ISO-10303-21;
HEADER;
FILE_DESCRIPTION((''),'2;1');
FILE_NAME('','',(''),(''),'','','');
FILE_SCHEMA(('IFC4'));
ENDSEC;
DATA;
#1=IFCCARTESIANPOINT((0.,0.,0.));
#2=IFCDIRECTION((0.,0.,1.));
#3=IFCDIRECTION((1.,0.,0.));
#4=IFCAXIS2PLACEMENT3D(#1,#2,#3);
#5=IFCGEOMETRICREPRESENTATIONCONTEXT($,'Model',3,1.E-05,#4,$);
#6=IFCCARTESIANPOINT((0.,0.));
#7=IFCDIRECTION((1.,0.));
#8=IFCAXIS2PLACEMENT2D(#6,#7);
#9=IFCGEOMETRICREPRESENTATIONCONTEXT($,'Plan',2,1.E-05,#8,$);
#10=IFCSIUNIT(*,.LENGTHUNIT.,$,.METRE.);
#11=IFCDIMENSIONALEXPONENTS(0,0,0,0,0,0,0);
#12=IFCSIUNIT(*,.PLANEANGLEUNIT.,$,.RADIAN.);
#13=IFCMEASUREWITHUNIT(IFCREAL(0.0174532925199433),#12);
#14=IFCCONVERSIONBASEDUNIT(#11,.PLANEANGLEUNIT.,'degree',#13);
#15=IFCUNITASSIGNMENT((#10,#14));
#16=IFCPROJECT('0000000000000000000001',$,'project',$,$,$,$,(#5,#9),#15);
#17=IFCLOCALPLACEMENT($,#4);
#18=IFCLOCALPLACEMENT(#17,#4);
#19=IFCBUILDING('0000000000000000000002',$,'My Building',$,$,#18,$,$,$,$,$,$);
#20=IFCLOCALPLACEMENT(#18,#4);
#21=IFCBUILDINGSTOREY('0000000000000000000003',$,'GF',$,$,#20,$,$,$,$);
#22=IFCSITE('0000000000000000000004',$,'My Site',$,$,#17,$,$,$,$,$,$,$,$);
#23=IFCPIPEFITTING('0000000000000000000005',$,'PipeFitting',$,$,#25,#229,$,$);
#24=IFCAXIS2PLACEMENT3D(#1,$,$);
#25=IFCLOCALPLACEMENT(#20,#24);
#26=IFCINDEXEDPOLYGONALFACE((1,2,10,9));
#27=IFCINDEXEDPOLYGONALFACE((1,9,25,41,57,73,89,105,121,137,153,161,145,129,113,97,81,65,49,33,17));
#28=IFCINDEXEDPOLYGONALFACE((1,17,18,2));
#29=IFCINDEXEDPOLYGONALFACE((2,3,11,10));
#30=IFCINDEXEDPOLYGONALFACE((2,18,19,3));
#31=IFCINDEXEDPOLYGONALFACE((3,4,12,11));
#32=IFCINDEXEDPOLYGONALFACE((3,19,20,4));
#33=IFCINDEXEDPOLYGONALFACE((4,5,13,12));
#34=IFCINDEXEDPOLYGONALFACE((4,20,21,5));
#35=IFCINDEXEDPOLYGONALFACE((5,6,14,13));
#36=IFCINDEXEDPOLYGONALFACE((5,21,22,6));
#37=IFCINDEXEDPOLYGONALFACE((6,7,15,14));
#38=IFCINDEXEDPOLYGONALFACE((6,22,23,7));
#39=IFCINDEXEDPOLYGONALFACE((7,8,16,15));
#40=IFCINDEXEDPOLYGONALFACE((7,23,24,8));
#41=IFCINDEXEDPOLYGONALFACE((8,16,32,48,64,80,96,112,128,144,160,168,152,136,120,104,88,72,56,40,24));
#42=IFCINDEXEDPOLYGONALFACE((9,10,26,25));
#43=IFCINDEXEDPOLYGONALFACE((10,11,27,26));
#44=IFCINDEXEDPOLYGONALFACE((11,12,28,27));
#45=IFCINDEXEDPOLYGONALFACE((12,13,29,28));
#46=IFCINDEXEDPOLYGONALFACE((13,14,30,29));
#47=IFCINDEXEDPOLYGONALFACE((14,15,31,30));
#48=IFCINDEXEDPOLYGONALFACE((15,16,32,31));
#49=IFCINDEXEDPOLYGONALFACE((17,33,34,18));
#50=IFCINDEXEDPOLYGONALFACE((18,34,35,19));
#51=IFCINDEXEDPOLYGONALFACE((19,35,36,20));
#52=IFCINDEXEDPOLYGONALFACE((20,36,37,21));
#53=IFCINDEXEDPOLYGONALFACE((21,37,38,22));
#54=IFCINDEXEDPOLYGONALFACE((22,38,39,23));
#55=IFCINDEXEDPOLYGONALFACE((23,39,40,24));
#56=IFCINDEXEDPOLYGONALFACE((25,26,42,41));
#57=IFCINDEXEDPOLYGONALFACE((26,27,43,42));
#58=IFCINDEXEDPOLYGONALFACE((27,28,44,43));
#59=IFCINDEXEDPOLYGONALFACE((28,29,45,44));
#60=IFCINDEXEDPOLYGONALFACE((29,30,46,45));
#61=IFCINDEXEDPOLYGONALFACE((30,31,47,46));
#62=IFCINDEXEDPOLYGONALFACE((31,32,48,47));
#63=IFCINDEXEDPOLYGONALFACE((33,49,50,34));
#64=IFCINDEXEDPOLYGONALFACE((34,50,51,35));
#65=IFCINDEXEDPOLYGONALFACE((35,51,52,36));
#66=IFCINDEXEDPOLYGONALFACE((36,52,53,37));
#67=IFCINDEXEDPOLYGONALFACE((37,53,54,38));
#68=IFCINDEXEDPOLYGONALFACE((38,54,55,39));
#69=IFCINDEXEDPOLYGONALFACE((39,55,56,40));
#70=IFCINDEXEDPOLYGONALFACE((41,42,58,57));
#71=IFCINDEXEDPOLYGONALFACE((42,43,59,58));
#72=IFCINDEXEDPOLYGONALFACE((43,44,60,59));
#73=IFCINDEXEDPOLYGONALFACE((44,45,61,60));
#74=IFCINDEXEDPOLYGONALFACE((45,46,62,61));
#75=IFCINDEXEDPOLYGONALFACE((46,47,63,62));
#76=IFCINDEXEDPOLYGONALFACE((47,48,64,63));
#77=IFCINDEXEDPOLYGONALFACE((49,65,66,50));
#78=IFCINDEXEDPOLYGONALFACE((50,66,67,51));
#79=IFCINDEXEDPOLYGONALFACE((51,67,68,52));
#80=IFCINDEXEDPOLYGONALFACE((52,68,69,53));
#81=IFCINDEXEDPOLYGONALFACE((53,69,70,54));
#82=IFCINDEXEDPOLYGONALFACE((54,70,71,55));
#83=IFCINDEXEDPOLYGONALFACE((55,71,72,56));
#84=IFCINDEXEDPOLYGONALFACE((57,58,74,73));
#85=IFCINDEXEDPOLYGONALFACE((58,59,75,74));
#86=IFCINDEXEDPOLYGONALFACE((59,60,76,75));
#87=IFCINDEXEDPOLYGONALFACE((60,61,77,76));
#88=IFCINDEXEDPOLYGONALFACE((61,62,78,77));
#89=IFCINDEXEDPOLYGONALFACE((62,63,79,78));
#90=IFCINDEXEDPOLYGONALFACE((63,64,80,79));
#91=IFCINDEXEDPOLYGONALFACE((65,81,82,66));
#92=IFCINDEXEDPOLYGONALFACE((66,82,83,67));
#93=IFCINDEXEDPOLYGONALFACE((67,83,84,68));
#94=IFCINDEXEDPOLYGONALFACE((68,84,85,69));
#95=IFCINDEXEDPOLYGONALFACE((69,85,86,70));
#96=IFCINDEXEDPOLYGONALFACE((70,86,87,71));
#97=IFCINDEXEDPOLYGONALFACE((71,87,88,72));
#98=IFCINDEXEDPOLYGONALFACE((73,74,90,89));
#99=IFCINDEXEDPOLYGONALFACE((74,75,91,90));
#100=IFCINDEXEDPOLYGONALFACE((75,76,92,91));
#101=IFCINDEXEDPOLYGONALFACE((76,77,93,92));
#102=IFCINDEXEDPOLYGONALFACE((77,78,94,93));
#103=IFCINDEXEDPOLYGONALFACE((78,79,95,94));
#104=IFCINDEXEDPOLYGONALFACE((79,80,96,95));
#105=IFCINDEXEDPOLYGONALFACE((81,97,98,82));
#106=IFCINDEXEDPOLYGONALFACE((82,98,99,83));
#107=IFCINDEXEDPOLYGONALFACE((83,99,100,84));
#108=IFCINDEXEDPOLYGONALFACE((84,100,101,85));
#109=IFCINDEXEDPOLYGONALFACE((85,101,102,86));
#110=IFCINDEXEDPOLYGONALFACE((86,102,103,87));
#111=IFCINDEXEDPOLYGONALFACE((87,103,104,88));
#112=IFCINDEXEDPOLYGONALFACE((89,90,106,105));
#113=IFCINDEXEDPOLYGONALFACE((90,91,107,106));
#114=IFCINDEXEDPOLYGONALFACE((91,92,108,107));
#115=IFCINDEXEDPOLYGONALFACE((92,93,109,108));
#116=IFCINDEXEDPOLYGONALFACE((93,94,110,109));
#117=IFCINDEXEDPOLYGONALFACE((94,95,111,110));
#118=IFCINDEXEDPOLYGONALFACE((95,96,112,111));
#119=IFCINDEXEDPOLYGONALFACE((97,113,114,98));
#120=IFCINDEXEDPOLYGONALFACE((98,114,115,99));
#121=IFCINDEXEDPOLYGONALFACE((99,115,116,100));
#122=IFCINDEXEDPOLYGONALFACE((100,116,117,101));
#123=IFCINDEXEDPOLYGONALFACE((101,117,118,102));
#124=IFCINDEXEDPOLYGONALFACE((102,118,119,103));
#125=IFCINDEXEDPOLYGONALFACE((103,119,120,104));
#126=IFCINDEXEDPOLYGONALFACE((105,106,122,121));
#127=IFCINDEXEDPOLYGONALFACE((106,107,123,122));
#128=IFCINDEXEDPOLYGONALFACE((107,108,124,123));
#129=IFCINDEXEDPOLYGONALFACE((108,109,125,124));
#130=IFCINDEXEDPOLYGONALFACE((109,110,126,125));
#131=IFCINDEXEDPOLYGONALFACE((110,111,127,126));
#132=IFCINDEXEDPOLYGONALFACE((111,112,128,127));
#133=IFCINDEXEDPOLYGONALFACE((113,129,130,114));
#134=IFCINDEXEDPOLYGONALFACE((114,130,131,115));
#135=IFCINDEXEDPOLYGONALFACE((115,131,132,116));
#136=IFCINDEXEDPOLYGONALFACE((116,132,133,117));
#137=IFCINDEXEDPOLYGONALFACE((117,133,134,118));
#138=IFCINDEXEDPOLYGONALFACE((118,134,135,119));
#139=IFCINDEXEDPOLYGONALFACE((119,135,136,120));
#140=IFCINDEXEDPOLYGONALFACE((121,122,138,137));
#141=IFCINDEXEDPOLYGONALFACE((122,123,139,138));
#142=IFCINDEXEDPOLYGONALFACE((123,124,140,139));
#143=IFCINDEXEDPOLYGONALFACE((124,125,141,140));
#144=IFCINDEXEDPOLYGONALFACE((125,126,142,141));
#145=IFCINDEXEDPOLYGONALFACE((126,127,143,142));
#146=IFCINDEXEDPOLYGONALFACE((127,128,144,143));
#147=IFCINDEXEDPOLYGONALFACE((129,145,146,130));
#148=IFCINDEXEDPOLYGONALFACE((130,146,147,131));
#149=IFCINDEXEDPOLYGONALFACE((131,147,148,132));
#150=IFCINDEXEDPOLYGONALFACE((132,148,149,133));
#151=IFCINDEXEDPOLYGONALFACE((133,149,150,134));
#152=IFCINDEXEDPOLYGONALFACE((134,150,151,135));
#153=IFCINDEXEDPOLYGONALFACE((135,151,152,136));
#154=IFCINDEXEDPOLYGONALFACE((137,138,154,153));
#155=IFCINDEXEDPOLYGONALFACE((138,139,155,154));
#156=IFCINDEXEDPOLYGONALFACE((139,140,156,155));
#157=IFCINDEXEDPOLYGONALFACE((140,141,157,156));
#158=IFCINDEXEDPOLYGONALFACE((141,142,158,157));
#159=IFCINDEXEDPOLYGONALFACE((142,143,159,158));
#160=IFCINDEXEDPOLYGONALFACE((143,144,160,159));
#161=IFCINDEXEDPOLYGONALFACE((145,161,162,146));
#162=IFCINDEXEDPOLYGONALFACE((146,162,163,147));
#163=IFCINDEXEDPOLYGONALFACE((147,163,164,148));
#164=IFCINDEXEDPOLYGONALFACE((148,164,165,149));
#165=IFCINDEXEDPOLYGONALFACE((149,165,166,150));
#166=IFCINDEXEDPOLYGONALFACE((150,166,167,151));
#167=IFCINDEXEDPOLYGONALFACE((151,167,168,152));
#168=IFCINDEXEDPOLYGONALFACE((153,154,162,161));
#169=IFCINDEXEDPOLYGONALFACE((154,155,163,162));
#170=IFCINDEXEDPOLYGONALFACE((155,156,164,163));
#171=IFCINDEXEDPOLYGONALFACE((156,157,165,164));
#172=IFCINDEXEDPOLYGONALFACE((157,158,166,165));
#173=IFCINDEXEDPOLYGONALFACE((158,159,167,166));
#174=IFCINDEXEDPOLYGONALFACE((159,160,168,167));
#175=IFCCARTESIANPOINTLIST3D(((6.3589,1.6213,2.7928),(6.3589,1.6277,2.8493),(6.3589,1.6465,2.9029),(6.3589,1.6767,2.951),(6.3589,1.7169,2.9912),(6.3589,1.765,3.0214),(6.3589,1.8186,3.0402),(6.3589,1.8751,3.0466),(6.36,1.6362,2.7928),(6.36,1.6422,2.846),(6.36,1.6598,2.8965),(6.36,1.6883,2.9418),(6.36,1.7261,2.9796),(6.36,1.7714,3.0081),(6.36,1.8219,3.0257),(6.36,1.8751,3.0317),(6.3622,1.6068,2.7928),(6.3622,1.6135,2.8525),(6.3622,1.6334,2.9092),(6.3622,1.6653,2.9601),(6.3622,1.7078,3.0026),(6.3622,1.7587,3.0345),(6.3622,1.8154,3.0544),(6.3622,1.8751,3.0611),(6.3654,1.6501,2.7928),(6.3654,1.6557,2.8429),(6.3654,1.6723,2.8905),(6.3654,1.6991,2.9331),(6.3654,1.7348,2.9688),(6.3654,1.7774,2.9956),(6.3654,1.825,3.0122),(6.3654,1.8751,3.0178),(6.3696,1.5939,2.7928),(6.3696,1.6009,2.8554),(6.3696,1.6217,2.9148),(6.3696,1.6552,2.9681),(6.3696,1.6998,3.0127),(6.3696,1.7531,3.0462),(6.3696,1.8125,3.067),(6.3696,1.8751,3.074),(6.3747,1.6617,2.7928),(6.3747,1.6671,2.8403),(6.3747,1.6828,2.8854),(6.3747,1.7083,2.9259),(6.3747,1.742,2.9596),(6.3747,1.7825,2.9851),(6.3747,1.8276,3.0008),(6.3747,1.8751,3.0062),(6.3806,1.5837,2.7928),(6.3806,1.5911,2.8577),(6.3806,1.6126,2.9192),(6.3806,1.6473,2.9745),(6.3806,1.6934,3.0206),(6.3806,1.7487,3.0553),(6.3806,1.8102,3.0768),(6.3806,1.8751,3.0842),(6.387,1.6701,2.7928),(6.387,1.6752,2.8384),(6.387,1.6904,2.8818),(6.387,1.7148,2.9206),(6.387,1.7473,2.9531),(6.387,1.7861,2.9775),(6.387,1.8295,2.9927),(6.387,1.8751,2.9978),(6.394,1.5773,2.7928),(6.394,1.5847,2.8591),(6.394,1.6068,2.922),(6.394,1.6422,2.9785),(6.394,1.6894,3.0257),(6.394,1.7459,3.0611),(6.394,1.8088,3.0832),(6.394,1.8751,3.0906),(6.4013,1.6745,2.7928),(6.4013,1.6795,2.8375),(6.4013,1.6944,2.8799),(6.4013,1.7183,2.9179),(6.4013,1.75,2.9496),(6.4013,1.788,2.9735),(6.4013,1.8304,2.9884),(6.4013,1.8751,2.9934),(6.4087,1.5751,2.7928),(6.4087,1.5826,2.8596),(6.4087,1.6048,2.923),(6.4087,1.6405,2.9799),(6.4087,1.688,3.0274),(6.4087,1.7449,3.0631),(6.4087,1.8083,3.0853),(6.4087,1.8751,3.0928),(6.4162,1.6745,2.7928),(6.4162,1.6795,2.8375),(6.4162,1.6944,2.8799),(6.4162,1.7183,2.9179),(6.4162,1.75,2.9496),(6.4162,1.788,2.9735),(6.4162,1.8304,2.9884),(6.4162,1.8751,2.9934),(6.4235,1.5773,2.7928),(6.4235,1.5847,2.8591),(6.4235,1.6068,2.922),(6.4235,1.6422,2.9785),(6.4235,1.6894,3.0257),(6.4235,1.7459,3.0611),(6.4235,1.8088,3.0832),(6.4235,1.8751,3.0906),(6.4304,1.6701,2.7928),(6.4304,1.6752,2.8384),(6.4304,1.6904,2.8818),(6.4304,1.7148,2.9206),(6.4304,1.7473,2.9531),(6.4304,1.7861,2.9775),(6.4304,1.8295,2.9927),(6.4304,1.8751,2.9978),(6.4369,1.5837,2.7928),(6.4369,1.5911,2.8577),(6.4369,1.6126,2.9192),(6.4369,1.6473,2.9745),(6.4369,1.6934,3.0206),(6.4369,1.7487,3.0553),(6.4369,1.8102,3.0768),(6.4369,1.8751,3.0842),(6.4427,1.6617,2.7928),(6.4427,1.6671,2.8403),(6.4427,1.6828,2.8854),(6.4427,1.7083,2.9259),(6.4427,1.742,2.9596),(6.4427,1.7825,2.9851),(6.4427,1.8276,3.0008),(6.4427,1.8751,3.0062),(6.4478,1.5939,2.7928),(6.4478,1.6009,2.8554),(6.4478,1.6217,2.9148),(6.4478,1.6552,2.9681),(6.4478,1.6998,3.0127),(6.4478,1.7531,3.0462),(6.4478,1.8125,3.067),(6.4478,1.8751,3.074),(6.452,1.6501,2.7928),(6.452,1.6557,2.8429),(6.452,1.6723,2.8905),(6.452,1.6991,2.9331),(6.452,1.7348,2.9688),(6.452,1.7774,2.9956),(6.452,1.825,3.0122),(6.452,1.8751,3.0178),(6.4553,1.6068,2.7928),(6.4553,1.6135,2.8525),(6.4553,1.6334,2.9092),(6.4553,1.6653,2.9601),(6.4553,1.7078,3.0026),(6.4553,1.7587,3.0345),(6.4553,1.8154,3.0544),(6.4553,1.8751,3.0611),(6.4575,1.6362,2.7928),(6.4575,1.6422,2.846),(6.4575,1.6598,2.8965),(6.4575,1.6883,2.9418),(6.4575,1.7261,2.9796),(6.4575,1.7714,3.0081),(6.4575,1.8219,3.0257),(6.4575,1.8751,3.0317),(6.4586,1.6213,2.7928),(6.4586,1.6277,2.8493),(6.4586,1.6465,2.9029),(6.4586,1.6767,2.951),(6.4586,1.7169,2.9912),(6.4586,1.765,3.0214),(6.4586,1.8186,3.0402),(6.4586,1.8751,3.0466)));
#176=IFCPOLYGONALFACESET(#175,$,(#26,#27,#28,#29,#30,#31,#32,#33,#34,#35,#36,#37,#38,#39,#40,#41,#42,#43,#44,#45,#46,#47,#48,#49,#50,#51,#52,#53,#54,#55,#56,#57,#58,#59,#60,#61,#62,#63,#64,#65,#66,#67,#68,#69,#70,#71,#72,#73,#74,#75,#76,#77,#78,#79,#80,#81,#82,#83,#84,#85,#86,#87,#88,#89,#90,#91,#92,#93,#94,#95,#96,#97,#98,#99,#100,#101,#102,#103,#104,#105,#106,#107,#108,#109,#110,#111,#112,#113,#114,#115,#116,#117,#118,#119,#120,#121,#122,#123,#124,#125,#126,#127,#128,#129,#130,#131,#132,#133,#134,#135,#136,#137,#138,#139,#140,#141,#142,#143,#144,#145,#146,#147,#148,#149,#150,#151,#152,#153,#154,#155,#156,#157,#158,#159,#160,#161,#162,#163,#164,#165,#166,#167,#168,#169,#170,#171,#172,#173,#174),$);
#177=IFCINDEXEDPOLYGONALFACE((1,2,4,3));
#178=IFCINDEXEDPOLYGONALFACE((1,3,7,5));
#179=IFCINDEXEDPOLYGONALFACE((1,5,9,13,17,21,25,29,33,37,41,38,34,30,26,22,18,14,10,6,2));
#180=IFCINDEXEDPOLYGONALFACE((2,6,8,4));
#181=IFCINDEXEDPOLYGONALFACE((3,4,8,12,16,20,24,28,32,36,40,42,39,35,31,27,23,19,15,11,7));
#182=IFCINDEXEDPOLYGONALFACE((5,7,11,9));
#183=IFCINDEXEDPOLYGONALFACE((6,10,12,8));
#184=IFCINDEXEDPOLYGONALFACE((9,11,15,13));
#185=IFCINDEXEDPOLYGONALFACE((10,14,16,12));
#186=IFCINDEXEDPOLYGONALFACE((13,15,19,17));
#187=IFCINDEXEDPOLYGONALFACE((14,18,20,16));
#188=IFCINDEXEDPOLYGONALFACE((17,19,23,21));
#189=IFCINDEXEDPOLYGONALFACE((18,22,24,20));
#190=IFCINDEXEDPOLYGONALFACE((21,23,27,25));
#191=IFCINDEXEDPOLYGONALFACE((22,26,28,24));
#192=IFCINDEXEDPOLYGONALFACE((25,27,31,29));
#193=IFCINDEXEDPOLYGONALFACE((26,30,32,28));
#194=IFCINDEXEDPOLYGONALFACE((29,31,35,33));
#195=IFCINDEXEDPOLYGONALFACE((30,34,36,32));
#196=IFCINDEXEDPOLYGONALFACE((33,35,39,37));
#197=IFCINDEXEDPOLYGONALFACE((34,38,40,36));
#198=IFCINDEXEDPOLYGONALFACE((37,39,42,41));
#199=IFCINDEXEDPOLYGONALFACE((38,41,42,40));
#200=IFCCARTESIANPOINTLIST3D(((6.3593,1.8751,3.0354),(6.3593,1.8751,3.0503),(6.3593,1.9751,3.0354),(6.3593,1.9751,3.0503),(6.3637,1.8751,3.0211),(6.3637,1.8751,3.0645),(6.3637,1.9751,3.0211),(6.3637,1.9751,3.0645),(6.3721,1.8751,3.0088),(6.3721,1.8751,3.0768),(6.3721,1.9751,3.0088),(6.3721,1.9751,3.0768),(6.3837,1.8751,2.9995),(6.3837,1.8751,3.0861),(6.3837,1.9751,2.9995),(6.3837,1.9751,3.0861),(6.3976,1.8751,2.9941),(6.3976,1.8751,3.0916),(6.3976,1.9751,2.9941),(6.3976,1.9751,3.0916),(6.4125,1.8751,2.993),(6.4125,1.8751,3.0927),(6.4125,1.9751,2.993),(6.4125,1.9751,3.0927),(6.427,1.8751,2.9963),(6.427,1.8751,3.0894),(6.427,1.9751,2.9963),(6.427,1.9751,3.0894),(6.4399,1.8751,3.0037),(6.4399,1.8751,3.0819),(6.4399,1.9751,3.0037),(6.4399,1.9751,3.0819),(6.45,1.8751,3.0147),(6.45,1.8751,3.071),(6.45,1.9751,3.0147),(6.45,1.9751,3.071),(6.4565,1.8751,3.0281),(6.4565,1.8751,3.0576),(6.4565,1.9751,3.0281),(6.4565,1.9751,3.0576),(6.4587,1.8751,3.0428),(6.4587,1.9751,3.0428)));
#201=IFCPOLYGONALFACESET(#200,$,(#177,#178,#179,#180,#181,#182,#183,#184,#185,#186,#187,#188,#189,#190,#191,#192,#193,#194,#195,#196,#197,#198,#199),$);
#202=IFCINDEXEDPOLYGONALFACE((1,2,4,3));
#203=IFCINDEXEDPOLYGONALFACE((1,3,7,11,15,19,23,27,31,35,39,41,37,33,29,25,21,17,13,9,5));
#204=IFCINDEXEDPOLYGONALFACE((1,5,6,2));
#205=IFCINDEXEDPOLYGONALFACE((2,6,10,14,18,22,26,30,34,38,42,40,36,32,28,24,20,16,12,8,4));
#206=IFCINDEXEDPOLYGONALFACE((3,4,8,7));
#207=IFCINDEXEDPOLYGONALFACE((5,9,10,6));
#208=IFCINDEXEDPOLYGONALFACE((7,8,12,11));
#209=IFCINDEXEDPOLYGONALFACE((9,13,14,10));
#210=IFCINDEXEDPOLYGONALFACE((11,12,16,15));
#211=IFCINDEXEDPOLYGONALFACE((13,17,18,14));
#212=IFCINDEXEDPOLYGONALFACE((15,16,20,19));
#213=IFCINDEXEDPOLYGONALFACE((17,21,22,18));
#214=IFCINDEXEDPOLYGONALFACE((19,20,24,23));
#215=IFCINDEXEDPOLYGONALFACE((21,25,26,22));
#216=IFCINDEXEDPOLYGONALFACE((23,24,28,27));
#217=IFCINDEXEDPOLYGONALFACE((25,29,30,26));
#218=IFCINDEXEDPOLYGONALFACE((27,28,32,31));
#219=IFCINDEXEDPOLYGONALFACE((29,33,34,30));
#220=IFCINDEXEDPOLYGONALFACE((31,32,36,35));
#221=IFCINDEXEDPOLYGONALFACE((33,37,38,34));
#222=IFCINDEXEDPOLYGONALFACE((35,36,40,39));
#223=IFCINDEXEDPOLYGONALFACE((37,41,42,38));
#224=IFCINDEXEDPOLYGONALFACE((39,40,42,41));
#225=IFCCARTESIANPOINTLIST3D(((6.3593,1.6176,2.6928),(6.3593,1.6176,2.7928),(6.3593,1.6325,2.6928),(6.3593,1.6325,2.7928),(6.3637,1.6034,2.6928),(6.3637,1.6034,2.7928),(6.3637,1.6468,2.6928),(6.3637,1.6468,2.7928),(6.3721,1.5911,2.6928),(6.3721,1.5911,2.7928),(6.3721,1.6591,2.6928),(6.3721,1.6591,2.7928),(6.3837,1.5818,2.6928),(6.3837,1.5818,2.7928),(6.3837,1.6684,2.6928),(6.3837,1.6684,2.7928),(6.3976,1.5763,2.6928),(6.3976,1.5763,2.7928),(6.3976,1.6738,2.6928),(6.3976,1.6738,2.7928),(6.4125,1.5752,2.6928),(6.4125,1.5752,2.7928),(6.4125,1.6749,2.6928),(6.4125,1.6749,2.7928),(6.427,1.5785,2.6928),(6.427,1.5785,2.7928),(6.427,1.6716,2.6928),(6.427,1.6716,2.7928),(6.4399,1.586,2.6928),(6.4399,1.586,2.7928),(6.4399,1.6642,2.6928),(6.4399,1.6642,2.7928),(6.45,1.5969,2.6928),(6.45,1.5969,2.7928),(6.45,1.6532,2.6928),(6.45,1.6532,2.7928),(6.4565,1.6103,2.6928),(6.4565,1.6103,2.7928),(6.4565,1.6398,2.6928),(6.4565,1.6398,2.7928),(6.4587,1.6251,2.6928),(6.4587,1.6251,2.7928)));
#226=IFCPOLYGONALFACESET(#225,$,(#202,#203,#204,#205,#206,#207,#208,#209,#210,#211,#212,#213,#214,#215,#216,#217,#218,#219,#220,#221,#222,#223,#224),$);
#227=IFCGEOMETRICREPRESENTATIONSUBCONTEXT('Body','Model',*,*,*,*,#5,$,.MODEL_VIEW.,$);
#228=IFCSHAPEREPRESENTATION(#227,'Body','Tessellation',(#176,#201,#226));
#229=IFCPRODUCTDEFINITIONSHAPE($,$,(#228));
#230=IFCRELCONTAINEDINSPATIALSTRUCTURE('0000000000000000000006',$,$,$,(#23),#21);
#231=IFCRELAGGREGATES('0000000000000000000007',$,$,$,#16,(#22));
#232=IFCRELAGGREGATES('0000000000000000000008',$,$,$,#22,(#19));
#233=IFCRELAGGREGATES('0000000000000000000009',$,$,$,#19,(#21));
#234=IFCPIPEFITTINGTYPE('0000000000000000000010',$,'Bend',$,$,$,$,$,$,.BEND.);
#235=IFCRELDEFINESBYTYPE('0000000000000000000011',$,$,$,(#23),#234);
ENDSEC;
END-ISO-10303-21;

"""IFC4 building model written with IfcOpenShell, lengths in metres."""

from ifc_helpers import new_model, entity, si_unit, converted_unit, frame, origin_with_axes, origin_2d_with_axis, place, context, subcontext, project, spatial, line, indexed_curve, circle, outline, extrude, source, transform, mapped, type_object, type_shapes, element, save


model = new_model("IFC4")

# Units and contexts
model_context = context("Model", 3, precision=1e-05, world=origin_with_axes())
plan_context = context("Plan", 2, precision=1e-05, world=origin_2d_with_axis())
body_context_1 = subcontext(model_context, "Body", "Model", "MODEL_VIEW")
ifc_project = project(units=[si_unit("LENGTHUNIT", "METRE"), converted_unit("PLANEANGLEUNIT", "degree", entity("IfcReal", 0.0174532925199433), si_unit("PLANEANGLEUNIT", "RADIAN"), dimensions=[0, 0, 0, 0, 0, 0, 0])], contexts=[model_context, plan_context])

# Site, building, storey
site_placement = place(None, origin_with_axes())
site = spatial("IfcSite", under=ifc_project, at=site_placement, Name="My Site")
building_placement = place(site_placement, origin_with_axes())
building = spatial("IfcBuilding", under=site, at=building_placement, Name="My Building")
storey_placement = place(building_placement, origin_with_axes())
storey = spatial("IfcBuildingStorey", under=building, at=storey_placement, Name="GF")

# Pipe fitting, opening
pipe_fitting_type = type_object("IfcPipeFittingType", Name="Bend", PredefinedType="BEND")
shared_shape_1 = source(origin_with_axes(), body_context_1, "Body", "SolidModel", [
    entity("IfcSweptDiskSolid", entity("IfcIndexedPolyCurve", entity("IfcCartesianPointList3D", [[0.0, 0.0, 0.1], [0.0, -0.0732, 0.2768], [0.0, -0.25, 0.35]]), [entity("IfcArcIndex", [1, 2, 3])]), 0.05),
    extrude(circle(Radius=0.05), origin_with_axes(), (0.0, 0.0, 1.0), 0.1),
    extrude(circle(Radius=0.05), frame((0.0, -0.25, 0.35), z_axis=(0.0, -1.0, 0.0), x_axis=(1.0, 0.0, 0.0)), (0.0, 0.0, 1.0), 0.1),
])
type_shapes(pipe_fitting_type, [shared_shape_1])
pipe_fitting_1_placement = place(storey_placement, frame((6.4087, 1.9751, 3.0428), z_axis=(0.0, -1.0, 0.0), x_axis=(1.0, 0.0, 0.0)))
pipe_fitting_1 = element("IfcPipeFitting", 1, at=pipe_fitting_1_placement, inside=storey, type_object=pipe_fitting_type, Name="PipeFitting", context=body_context_1, shape_type="MappedRepresentation", body=[
    mapped(shared_shape_1, transform((0.0, 0.0, 0.0), x_axis=(1.0, 0.0, 0.0), y_axis=(0.0, 1.0, 0.0), z_axis=(0.0, 0.0, 1.0), scale=1.0)),
])
opening_1_placement = place(pipe_fitting_1_placement, frame((-6.4087, -3.0428, 1.9751), z_axis=(0.0, 1.0, 0.0), x_axis=(1.0, 0.0, 0.0)))
element("IfcOpeningElement", 2, at=opening_1_placement, cuts=pipe_fitting_1, PredefinedType="OPENING", context=body_context_1, shape_type="SweptSolid", body=[
    extrude(outline(indexed_curve([(0.0, 0.0), (0.5, 0.0), (0.5, 0.5), (0.0, 0.5)], segments=[line(1, 2, 3, 4, 1)])), origin_with_axes(), (0.0, 0.0, 1.0), 0.5),
])

save(model, "model.ifc")
